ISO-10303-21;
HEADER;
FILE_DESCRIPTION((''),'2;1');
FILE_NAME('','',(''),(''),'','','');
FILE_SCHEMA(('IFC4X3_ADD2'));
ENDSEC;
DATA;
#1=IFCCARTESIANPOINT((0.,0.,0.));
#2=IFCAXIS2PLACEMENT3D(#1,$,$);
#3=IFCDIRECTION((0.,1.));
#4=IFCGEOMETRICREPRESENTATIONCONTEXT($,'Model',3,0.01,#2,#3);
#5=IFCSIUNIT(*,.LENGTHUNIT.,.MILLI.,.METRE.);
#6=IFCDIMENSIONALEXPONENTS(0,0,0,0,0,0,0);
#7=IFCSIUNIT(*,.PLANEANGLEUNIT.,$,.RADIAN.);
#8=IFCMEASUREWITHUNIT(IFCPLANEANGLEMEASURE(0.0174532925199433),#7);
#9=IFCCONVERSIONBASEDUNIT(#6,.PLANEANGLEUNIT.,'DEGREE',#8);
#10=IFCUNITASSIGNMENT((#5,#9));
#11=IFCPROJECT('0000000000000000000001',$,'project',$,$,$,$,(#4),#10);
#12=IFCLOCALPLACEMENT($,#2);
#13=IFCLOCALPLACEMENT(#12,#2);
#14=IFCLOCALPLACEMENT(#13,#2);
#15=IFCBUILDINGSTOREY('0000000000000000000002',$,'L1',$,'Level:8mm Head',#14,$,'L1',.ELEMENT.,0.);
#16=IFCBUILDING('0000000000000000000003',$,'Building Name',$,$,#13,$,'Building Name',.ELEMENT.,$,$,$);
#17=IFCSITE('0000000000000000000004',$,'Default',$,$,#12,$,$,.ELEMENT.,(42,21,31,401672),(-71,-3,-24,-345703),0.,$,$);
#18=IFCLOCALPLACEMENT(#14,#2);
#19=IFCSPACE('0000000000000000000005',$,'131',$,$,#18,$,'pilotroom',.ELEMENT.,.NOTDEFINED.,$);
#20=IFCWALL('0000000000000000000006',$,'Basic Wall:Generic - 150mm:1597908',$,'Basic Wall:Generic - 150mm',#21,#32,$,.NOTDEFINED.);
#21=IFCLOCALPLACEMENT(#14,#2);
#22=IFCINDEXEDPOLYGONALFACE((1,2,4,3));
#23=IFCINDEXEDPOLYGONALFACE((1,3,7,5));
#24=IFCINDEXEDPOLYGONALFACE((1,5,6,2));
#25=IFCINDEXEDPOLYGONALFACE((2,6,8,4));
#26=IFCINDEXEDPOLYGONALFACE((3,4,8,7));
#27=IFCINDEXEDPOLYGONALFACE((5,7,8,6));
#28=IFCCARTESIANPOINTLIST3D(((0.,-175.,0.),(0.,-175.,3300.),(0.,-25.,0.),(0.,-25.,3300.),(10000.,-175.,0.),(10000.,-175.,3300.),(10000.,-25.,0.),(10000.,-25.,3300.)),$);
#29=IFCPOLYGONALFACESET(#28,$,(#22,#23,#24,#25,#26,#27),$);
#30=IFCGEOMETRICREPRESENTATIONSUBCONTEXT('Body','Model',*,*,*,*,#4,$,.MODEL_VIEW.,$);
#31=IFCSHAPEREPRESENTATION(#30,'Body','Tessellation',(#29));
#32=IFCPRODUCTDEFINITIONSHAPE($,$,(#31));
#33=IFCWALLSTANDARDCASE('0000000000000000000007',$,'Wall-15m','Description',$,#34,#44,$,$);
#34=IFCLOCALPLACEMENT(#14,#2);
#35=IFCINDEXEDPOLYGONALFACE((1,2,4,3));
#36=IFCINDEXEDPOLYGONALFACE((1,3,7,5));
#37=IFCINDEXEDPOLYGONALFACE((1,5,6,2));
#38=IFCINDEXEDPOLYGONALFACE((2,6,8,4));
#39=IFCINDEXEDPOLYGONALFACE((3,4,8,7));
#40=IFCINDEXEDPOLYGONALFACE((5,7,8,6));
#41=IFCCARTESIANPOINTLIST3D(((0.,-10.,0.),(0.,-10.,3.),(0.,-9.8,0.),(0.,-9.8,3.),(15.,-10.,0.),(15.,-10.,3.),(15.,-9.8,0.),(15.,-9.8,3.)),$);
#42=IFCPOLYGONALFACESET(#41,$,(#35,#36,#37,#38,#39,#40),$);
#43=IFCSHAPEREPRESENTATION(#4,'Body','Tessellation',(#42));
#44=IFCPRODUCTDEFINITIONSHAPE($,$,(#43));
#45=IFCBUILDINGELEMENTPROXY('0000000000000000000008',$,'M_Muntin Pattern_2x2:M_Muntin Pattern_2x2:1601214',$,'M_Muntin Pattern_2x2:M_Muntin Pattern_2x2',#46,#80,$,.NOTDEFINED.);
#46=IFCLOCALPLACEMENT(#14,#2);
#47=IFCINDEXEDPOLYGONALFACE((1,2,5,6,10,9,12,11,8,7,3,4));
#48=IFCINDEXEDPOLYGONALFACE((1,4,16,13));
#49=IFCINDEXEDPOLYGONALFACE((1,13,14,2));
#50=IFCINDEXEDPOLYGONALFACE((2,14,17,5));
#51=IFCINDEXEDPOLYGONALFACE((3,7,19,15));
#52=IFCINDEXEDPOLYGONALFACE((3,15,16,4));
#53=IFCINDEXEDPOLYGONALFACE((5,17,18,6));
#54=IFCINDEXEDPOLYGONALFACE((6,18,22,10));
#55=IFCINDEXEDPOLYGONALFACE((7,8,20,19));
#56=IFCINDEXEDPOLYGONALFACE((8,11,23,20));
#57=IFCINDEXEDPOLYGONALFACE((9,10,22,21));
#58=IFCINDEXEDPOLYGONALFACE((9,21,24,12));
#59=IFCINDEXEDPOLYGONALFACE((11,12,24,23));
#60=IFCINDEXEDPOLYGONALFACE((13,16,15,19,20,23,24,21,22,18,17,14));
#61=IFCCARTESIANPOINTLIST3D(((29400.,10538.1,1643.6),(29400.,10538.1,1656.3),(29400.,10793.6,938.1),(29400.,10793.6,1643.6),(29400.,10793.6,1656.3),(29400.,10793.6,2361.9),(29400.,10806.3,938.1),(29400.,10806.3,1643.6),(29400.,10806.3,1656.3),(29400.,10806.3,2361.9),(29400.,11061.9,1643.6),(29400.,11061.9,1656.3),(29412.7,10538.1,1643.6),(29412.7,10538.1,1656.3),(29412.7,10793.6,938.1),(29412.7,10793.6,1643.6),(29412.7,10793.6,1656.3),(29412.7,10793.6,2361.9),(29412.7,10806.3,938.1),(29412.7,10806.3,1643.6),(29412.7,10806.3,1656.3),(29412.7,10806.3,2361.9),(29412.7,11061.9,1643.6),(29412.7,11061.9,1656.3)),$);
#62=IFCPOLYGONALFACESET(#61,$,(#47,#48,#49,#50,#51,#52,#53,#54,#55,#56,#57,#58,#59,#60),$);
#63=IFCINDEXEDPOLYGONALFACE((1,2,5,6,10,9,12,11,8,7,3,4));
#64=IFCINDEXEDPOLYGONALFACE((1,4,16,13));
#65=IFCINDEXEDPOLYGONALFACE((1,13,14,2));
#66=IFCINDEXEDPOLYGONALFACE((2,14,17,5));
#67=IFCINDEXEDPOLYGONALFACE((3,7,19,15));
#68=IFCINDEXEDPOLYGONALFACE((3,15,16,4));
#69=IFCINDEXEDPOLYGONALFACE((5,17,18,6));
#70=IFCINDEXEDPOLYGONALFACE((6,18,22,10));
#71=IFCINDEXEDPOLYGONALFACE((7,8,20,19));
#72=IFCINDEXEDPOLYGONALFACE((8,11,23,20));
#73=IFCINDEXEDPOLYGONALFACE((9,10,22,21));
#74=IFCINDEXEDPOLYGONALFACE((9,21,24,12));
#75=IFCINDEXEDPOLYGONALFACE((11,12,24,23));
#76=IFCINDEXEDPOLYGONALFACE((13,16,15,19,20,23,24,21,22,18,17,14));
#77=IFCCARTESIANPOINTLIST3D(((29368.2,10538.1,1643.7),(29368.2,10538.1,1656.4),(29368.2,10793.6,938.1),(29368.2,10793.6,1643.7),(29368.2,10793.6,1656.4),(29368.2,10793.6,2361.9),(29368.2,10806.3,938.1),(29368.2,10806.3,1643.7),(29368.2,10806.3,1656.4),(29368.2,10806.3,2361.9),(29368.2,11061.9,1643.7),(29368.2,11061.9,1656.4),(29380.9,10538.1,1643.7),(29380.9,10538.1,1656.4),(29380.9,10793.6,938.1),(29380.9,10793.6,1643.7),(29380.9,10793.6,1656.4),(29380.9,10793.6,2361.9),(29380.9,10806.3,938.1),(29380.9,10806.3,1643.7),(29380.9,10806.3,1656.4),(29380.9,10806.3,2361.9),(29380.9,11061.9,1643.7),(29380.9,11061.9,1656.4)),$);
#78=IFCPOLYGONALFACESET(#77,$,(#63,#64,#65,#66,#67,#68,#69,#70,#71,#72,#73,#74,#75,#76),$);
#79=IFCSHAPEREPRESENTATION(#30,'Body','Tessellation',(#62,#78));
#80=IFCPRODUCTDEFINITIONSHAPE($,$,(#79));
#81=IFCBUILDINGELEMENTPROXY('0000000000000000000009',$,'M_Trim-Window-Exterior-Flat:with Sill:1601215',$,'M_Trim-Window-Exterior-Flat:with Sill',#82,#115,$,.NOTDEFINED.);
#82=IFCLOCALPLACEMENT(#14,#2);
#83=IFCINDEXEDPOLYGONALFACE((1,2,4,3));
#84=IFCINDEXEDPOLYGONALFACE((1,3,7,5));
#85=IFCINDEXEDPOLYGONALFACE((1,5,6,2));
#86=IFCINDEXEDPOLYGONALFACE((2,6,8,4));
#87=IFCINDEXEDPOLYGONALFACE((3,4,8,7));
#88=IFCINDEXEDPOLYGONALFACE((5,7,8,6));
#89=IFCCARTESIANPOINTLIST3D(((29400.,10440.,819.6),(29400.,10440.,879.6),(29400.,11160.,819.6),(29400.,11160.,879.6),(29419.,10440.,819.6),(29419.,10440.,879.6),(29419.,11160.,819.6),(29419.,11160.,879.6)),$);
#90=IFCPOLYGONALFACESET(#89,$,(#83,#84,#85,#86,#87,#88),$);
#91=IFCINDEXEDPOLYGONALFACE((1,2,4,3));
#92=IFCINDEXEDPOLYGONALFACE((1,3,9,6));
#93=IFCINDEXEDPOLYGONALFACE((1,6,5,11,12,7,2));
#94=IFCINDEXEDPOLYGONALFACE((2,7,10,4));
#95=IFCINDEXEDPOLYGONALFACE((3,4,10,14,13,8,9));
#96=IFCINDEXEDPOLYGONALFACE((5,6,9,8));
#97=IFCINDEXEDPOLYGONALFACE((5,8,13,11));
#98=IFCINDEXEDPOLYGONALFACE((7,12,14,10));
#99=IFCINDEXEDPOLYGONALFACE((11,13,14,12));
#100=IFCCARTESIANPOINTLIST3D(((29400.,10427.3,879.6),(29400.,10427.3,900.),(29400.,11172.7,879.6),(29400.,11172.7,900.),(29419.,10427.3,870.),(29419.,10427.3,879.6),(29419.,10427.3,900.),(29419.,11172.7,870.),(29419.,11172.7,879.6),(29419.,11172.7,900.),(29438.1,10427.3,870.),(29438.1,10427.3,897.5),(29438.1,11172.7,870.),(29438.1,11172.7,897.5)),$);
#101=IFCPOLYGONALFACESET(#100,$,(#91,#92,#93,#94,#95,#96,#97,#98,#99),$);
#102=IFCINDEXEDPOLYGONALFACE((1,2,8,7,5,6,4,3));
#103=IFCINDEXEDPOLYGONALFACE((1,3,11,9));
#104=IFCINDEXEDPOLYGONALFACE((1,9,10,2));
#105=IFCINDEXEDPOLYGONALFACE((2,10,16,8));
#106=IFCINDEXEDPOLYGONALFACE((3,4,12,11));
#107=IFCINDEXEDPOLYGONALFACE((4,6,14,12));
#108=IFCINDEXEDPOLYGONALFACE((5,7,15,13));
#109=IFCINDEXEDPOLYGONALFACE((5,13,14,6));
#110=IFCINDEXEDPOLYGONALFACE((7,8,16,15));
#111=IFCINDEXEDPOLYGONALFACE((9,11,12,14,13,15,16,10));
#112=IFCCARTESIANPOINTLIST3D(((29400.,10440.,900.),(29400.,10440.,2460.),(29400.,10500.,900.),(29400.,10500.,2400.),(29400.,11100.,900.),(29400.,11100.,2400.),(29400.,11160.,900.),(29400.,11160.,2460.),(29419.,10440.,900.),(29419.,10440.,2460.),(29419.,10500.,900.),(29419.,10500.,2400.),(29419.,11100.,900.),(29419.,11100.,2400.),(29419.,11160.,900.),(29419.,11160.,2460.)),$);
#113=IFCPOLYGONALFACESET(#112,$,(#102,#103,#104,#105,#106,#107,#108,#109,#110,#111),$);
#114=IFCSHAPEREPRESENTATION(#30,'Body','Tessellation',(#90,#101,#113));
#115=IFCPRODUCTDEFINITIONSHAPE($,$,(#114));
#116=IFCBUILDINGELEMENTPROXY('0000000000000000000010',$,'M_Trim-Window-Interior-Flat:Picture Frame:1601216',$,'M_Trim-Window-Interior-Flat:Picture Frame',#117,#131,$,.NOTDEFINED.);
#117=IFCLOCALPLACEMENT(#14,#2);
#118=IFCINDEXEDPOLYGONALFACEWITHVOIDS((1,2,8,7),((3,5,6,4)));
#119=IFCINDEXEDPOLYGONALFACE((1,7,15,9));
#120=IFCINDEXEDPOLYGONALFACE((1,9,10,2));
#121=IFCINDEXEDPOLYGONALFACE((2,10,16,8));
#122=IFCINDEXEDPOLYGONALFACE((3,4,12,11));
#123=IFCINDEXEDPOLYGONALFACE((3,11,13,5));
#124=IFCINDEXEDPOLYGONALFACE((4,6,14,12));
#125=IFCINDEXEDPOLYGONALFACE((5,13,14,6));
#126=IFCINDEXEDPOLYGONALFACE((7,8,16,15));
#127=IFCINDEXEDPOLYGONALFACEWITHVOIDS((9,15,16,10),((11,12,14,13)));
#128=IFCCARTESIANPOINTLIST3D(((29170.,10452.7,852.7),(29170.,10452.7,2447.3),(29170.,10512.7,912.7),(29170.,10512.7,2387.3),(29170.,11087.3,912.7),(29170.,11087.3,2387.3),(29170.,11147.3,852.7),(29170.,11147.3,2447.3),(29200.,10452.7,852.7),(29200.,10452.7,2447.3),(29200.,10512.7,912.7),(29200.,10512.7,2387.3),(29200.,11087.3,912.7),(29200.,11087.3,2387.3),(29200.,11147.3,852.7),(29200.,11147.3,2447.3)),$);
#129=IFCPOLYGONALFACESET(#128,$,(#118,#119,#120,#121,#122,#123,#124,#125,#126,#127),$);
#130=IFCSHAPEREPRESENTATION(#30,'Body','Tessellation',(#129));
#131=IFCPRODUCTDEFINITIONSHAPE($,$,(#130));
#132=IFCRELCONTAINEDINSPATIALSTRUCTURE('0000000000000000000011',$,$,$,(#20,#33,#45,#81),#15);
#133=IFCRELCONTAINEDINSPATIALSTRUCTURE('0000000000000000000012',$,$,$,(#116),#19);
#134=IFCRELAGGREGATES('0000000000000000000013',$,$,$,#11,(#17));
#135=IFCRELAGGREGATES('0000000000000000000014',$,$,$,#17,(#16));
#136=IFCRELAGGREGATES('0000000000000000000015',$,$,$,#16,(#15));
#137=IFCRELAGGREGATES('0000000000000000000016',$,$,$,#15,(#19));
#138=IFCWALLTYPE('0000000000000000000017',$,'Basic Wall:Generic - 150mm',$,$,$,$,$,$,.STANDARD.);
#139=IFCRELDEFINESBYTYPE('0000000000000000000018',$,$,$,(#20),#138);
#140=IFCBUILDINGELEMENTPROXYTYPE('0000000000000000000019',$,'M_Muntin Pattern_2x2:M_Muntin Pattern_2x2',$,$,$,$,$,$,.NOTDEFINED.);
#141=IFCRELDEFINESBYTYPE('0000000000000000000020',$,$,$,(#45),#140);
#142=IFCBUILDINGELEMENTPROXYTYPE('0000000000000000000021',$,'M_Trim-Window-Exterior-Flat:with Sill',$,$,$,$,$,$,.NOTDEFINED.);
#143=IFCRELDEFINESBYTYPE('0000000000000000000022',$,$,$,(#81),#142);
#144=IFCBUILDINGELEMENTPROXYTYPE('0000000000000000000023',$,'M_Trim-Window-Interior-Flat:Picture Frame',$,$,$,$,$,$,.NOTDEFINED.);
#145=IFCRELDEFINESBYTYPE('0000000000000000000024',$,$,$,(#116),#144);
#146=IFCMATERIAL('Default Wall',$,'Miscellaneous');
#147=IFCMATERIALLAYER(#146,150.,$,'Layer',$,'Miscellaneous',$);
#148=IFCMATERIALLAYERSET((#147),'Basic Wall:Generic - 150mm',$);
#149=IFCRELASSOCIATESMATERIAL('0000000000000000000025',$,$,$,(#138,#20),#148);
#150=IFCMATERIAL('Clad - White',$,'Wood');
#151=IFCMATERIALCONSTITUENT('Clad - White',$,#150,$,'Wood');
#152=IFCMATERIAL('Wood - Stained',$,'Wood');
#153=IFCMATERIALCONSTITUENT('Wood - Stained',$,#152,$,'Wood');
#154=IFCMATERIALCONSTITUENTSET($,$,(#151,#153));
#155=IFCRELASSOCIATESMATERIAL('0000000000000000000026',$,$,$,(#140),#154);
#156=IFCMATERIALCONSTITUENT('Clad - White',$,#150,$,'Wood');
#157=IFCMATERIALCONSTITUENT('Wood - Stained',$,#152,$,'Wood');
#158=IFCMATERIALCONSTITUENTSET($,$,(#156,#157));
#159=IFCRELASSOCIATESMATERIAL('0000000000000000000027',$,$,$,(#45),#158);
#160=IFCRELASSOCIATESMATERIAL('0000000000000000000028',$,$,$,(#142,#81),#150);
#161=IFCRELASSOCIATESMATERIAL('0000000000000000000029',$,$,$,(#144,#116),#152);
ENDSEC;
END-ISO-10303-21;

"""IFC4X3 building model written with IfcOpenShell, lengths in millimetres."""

from ifc_helpers import new_model, entity, si_unit, converted_unit, direction, frame, frame_2d, origin, place, context, subcontext, project, spatial, polyline, rectangle, outline, extrude, source, transform, mapped, material, layer, layer_set, constituent, constituent_set, type_object, type_shapes, element, save


model = new_model("IFC4X3")

# Units and contexts
model_context = context("Model", 3, precision=0.01, world=origin(), true_north=direction((0.0, 1.0)))
body_context = subcontext(model_context, "Body", "Model", "MODEL_VIEW")
ifc_project = project(units=[si_unit("LENGTHUNIT", "METRE", prefix="MILLI"), converted_unit("PLANEANGLEUNIT", "DEGREE", entity("IfcPlaneAngleMeasure", 0.0174532925199433), si_unit("PLANEANGLEUNIT", "RADIAN"), dimensions=[0, 0, 0, 0, 0, 0, 0])], contexts=[model_context])

# Site, building, storey
site_placement = place(None, origin())
site = spatial("IfcSite", under=ifc_project, at=site_placement, Name="Default", CompositionType="ELEMENT", RefLatitude=(42, 21, 31, 401672), RefLongitude=(-71, -3, -24, -345703), RefElevation=0.0)
building_placement = place(site_placement, origin())
building = spatial("IfcBuilding", under=site, at=building_placement, Name="Building Name", LongName="Building Name", CompositionType="ELEMENT")
storey_placement = place(building_placement, origin())
storey = spatial("IfcBuildingStorey", under=building, at=storey_placement, Name="L1", ObjectType="Level:8mm Head", LongName="L1", CompositionType="ELEMENT", Elevation=0.0)

# Shared definitions
ifc_material_1 = material(Name="Default Wall", Category="Miscellaneous")

# Walls
ifc_layer_1 = layer(ifc_material_1, 150.0, Name="Layer", Category="Miscellaneous")
ifc_layer_set_1 = layer_set([ifc_layer_1], Name="Basic Wall:Generic - 150mm")
wall_type_1 = type_object("IfcWallType", Name="Basic Wall:Generic - 150mm", PredefinedType="STANDARD", material=ifc_layer_set_1)
wall_1_placement = place(storey_placement, frame((0.0, -100.0, 0.0)))
element("IfcWall", 1, at=wall_1_placement, inside=storey, type_object=wall_type_1, material=ifc_layer_set_1, Name="Basic Wall:Generic - 150mm:1597908", ObjectType="Basic Wall:Generic - 150mm", PredefinedType="NOTDEFINED", context=body_context, shape_type="SweptSolid", body=[
    extrude(rectangle(XDim=10000.0, YDim=150.0, at=frame_2d((5000.0, 0.0), x_axis=(-1.0, 0.0))), origin(), (0.0, 0.0, 1.0), 3300.0),
])
wall_2_placement = place(storey_placement, frame((0.0, -10.0, 0.0)))
element("IfcWallStandardCase", 2, at=wall_2_placement, inside=storey, Name="Wall-15m", Description="Description", context=model_context, shape_type="SweptSolid", body=[
    extrude(rectangle(XDim=15.0, YDim=0.2, at=frame_2d((7.5, 0.1))), frame((0.0, 0.0, 0.0), z_axis=(0.0, 0.0, 1.0)), (0.0, 0.0, 1.0), 3.0),
])

# Building element proxies
ifc_material_2 = material(Name="Clad - White", Category="Wood")
ifc_constituent_1 = constituent(ifc_material_2, Name="Clad - White", Category="Wood")
ifc_material_3 = material(Name="Wood - Stained", Category="Wood")
ifc_constituent_2 = constituent(ifc_material_3, Name="Wood - Stained", Category="Wood")
ifc_constituent_set_1 = constituent_set(constituents=[ifc_constituent_1, ifc_constituent_2])
ifc_constituent_3 = constituent(ifc_material_2, Name="Clad - White", Category="Wood")
ifc_constituent_4 = constituent(ifc_material_3, Name="Wood - Stained", Category="Wood")
ifc_constituent_set_2 = constituent_set(constituents=[ifc_constituent_3, ifc_constituent_4])
building_element_proxy_type_1 = type_object("IfcBuildingElementProxyType", Name="M_Muntin Pattern_2x2:M_Muntin Pattern_2x2", PredefinedType="NOTDEFINED", material=ifc_constituent_set_2)
shared_shape_1 = source(origin(), body_context, "Body", "SweptSolid", [
    extrude(outline(polyline([(6.4, -6.4), (711.9, -6.4), (711.9, 6.3), (6.4, 6.3), (6.4, 261.9), (-6.3, 261.9), (-6.3, 6.3), (-711.9, 6.3), (-711.9, -6.4), (-6.3, -6.4), (-6.3, -261.9), (6.4, -261.9), (6.4, -6.4)])), frame((0.0, -22.2, 711.9), z_axis=(0.0, 1.0, 0.0), x_axis=(0.0, 0.0, 1.0)), (0.0, 0.0, 1.0), 12.7),
    extrude(outline(polyline([(6.4, -6.4), (711.9, -6.4), (711.9, 6.3), (6.4, 6.3), (6.4, 261.9), (-6.3, 261.9), (-6.3, 6.3), (-711.9, 6.3), (-711.9, -6.4), (-6.3, -6.4), (-6.3, -261.9), (6.4, -261.9), (6.4, -6.4)])), frame((0.0, 9.5, 711.9), z_axis=(0.0, 1.0, 0.0), x_axis=(0.0, 0.0, 1.0)), (0.0, 0.0, 1.0), 12.7),
])
type_shapes(building_element_proxy_type_1, [shared_shape_1])
proxy_1_placement = place(storey_placement, frame((29390.5, 10800.0, 938.1), z_axis=(0.0, 0.0, 1.0), x_axis=(0.0, 1.0, 0.0)))
element("IfcBuildingElementProxy", 3, at=proxy_1_placement, inside=storey, type_object=building_element_proxy_type_1, material=ifc_constituent_set_1, Name="M_Muntin Pattern_2x2:M_Muntin Pattern_2x2:1601214", ObjectType="M_Muntin Pattern_2x2:M_Muntin Pattern_2x2", PredefinedType="NOTDEFINED", context=body_context, shape_type="MappedRepresentation", body=[
    mapped(shared_shape_1, transform((0.0, 0.0, 0.0), scale=1.0)),
])
building_element_proxy_type_2 = type_object("IfcBuildingElementProxyType", Name="M_Trim-Window-Exterior-Flat:with Sill", PredefinedType="NOTDEFINED", material=ifc_material_2)
shared_shape_2 = source(origin(), body_context, "Body", "SweptSolid", [
    extrude(rectangle(XDim=720.0, YDim=60.0, at=frame_2d((0.0, 0.0), x_axis=(1.0, 0.0))), frame((0.0, -1550.4, 0.0), z_axis=(0.0, 0.0, 1.0), x_axis=(-1.0, 0.0, 0.0)), (0.0, 0.0, 1.0), 19.1),
    extrude(outline(polyline([(-19.0, -15.2), (0.0, -15.2), (0.0, -5.7), (19.0, -5.7), (19.0, 14.8), (0.0, 14.8), (-19.0, 12.3), (-19.0, -15.2)])), frame((-372.7, -1514.8, 19.0), z_axis=(1.0, 0.0, 0.0), x_axis=(0.0, 0.0, -1.0)), (0.0, 0.0, 1.0), 745.4),
    extrude(outline(polyline([(-795.0, -360.0), (765.0, -360.0), (765.0, -300.0), (-735.0, -300.0), (-735.0, 300.0), (765.0, 300.0), (765.0, 360.0), (-795.0, 360.0), (-795.0, -360.0)])), frame((0.0, -735.0, 0.0), z_axis=(0.0, 0.0, 1.0), x_axis=(0.0, -1.0, 0.0)), (0.0, 0.0, 1.0), 19.1),
])
type_shapes(building_element_proxy_type_2, [shared_shape_2])
proxy_2_placement = place(storey_placement, frame((29400.0, 10800.0, 2400.0), z_axis=(1.0, 0.0, 0.0), x_axis=(0.0, 1.0, 0.0)))
element("IfcBuildingElementProxy", 4, at=proxy_2_placement, inside=storey, type_object=building_element_proxy_type_2, material=ifc_material_2, Name="M_Trim-Window-Exterior-Flat:with Sill:1601215", ObjectType="M_Trim-Window-Exterior-Flat:with Sill", PredefinedType="NOTDEFINED", context=body_context, shape_type="MappedRepresentation", body=[
    mapped(shared_shape_2, transform((0.0, 0.0, 0.0), scale=1.0)),
])

# Shared definitions
space_placement = place(storey_placement, origin())
space = spatial("IfcSpace", under=storey, at=space_placement, Name="131", LongName="pilotroom", CompositionType="ELEMENT", PredefinedType="NOTDEFINED")

# Building element proxy
building_element_proxy_type_3 = type_object("IfcBuildingElementProxyType", Name="M_Trim-Window-Interior-Flat:Picture Frame", PredefinedType="NOTDEFINED", material=ifc_material_3)
shared_shape_3 = source(origin(), body_context, "Body", "SweptSolid", [
    extrude(outline(polyline([(-347.3, -797.3), (347.3, -797.3), (347.3, 797.3), (-347.3, 797.3), (-347.3, -797.3)]), holes=[polyline([(-287.3, -737.3), (-287.3, 737.3), (287.3, 737.3), (287.3, -737.3), (-287.3, -737.3)])]), frame((0.0, -750.0, 0.0), z_axis=(0.0, 0.0, 1.0), x_axis=(-1.0, 0.0, 0.0)), (0.0, 0.0, 1.0), 30.0),
])
type_shapes(building_element_proxy_type_3, [shared_shape_3])
proxy_3_placement = place(space_placement, frame((29200.0, 10800.0, 2400.0), z_axis=(-1.0, 0.0, 0.0), x_axis=(0.0, -1.0, 0.0)))
element("IfcBuildingElementProxy", 5, at=proxy_3_placement, inside=space, type_object=building_element_proxy_type_3, material=ifc_material_3, Name="M_Trim-Window-Interior-Flat:Picture Frame:1601216", ObjectType="M_Trim-Window-Interior-Flat:Picture Frame", PredefinedType="NOTDEFINED", context=body_context, shape_type="MappedRepresentation", body=[
    mapped(shared_shape_3, transform((0.0, 0.0, 0.0), scale=1.0)),
])

save(model, "model.ifc")
